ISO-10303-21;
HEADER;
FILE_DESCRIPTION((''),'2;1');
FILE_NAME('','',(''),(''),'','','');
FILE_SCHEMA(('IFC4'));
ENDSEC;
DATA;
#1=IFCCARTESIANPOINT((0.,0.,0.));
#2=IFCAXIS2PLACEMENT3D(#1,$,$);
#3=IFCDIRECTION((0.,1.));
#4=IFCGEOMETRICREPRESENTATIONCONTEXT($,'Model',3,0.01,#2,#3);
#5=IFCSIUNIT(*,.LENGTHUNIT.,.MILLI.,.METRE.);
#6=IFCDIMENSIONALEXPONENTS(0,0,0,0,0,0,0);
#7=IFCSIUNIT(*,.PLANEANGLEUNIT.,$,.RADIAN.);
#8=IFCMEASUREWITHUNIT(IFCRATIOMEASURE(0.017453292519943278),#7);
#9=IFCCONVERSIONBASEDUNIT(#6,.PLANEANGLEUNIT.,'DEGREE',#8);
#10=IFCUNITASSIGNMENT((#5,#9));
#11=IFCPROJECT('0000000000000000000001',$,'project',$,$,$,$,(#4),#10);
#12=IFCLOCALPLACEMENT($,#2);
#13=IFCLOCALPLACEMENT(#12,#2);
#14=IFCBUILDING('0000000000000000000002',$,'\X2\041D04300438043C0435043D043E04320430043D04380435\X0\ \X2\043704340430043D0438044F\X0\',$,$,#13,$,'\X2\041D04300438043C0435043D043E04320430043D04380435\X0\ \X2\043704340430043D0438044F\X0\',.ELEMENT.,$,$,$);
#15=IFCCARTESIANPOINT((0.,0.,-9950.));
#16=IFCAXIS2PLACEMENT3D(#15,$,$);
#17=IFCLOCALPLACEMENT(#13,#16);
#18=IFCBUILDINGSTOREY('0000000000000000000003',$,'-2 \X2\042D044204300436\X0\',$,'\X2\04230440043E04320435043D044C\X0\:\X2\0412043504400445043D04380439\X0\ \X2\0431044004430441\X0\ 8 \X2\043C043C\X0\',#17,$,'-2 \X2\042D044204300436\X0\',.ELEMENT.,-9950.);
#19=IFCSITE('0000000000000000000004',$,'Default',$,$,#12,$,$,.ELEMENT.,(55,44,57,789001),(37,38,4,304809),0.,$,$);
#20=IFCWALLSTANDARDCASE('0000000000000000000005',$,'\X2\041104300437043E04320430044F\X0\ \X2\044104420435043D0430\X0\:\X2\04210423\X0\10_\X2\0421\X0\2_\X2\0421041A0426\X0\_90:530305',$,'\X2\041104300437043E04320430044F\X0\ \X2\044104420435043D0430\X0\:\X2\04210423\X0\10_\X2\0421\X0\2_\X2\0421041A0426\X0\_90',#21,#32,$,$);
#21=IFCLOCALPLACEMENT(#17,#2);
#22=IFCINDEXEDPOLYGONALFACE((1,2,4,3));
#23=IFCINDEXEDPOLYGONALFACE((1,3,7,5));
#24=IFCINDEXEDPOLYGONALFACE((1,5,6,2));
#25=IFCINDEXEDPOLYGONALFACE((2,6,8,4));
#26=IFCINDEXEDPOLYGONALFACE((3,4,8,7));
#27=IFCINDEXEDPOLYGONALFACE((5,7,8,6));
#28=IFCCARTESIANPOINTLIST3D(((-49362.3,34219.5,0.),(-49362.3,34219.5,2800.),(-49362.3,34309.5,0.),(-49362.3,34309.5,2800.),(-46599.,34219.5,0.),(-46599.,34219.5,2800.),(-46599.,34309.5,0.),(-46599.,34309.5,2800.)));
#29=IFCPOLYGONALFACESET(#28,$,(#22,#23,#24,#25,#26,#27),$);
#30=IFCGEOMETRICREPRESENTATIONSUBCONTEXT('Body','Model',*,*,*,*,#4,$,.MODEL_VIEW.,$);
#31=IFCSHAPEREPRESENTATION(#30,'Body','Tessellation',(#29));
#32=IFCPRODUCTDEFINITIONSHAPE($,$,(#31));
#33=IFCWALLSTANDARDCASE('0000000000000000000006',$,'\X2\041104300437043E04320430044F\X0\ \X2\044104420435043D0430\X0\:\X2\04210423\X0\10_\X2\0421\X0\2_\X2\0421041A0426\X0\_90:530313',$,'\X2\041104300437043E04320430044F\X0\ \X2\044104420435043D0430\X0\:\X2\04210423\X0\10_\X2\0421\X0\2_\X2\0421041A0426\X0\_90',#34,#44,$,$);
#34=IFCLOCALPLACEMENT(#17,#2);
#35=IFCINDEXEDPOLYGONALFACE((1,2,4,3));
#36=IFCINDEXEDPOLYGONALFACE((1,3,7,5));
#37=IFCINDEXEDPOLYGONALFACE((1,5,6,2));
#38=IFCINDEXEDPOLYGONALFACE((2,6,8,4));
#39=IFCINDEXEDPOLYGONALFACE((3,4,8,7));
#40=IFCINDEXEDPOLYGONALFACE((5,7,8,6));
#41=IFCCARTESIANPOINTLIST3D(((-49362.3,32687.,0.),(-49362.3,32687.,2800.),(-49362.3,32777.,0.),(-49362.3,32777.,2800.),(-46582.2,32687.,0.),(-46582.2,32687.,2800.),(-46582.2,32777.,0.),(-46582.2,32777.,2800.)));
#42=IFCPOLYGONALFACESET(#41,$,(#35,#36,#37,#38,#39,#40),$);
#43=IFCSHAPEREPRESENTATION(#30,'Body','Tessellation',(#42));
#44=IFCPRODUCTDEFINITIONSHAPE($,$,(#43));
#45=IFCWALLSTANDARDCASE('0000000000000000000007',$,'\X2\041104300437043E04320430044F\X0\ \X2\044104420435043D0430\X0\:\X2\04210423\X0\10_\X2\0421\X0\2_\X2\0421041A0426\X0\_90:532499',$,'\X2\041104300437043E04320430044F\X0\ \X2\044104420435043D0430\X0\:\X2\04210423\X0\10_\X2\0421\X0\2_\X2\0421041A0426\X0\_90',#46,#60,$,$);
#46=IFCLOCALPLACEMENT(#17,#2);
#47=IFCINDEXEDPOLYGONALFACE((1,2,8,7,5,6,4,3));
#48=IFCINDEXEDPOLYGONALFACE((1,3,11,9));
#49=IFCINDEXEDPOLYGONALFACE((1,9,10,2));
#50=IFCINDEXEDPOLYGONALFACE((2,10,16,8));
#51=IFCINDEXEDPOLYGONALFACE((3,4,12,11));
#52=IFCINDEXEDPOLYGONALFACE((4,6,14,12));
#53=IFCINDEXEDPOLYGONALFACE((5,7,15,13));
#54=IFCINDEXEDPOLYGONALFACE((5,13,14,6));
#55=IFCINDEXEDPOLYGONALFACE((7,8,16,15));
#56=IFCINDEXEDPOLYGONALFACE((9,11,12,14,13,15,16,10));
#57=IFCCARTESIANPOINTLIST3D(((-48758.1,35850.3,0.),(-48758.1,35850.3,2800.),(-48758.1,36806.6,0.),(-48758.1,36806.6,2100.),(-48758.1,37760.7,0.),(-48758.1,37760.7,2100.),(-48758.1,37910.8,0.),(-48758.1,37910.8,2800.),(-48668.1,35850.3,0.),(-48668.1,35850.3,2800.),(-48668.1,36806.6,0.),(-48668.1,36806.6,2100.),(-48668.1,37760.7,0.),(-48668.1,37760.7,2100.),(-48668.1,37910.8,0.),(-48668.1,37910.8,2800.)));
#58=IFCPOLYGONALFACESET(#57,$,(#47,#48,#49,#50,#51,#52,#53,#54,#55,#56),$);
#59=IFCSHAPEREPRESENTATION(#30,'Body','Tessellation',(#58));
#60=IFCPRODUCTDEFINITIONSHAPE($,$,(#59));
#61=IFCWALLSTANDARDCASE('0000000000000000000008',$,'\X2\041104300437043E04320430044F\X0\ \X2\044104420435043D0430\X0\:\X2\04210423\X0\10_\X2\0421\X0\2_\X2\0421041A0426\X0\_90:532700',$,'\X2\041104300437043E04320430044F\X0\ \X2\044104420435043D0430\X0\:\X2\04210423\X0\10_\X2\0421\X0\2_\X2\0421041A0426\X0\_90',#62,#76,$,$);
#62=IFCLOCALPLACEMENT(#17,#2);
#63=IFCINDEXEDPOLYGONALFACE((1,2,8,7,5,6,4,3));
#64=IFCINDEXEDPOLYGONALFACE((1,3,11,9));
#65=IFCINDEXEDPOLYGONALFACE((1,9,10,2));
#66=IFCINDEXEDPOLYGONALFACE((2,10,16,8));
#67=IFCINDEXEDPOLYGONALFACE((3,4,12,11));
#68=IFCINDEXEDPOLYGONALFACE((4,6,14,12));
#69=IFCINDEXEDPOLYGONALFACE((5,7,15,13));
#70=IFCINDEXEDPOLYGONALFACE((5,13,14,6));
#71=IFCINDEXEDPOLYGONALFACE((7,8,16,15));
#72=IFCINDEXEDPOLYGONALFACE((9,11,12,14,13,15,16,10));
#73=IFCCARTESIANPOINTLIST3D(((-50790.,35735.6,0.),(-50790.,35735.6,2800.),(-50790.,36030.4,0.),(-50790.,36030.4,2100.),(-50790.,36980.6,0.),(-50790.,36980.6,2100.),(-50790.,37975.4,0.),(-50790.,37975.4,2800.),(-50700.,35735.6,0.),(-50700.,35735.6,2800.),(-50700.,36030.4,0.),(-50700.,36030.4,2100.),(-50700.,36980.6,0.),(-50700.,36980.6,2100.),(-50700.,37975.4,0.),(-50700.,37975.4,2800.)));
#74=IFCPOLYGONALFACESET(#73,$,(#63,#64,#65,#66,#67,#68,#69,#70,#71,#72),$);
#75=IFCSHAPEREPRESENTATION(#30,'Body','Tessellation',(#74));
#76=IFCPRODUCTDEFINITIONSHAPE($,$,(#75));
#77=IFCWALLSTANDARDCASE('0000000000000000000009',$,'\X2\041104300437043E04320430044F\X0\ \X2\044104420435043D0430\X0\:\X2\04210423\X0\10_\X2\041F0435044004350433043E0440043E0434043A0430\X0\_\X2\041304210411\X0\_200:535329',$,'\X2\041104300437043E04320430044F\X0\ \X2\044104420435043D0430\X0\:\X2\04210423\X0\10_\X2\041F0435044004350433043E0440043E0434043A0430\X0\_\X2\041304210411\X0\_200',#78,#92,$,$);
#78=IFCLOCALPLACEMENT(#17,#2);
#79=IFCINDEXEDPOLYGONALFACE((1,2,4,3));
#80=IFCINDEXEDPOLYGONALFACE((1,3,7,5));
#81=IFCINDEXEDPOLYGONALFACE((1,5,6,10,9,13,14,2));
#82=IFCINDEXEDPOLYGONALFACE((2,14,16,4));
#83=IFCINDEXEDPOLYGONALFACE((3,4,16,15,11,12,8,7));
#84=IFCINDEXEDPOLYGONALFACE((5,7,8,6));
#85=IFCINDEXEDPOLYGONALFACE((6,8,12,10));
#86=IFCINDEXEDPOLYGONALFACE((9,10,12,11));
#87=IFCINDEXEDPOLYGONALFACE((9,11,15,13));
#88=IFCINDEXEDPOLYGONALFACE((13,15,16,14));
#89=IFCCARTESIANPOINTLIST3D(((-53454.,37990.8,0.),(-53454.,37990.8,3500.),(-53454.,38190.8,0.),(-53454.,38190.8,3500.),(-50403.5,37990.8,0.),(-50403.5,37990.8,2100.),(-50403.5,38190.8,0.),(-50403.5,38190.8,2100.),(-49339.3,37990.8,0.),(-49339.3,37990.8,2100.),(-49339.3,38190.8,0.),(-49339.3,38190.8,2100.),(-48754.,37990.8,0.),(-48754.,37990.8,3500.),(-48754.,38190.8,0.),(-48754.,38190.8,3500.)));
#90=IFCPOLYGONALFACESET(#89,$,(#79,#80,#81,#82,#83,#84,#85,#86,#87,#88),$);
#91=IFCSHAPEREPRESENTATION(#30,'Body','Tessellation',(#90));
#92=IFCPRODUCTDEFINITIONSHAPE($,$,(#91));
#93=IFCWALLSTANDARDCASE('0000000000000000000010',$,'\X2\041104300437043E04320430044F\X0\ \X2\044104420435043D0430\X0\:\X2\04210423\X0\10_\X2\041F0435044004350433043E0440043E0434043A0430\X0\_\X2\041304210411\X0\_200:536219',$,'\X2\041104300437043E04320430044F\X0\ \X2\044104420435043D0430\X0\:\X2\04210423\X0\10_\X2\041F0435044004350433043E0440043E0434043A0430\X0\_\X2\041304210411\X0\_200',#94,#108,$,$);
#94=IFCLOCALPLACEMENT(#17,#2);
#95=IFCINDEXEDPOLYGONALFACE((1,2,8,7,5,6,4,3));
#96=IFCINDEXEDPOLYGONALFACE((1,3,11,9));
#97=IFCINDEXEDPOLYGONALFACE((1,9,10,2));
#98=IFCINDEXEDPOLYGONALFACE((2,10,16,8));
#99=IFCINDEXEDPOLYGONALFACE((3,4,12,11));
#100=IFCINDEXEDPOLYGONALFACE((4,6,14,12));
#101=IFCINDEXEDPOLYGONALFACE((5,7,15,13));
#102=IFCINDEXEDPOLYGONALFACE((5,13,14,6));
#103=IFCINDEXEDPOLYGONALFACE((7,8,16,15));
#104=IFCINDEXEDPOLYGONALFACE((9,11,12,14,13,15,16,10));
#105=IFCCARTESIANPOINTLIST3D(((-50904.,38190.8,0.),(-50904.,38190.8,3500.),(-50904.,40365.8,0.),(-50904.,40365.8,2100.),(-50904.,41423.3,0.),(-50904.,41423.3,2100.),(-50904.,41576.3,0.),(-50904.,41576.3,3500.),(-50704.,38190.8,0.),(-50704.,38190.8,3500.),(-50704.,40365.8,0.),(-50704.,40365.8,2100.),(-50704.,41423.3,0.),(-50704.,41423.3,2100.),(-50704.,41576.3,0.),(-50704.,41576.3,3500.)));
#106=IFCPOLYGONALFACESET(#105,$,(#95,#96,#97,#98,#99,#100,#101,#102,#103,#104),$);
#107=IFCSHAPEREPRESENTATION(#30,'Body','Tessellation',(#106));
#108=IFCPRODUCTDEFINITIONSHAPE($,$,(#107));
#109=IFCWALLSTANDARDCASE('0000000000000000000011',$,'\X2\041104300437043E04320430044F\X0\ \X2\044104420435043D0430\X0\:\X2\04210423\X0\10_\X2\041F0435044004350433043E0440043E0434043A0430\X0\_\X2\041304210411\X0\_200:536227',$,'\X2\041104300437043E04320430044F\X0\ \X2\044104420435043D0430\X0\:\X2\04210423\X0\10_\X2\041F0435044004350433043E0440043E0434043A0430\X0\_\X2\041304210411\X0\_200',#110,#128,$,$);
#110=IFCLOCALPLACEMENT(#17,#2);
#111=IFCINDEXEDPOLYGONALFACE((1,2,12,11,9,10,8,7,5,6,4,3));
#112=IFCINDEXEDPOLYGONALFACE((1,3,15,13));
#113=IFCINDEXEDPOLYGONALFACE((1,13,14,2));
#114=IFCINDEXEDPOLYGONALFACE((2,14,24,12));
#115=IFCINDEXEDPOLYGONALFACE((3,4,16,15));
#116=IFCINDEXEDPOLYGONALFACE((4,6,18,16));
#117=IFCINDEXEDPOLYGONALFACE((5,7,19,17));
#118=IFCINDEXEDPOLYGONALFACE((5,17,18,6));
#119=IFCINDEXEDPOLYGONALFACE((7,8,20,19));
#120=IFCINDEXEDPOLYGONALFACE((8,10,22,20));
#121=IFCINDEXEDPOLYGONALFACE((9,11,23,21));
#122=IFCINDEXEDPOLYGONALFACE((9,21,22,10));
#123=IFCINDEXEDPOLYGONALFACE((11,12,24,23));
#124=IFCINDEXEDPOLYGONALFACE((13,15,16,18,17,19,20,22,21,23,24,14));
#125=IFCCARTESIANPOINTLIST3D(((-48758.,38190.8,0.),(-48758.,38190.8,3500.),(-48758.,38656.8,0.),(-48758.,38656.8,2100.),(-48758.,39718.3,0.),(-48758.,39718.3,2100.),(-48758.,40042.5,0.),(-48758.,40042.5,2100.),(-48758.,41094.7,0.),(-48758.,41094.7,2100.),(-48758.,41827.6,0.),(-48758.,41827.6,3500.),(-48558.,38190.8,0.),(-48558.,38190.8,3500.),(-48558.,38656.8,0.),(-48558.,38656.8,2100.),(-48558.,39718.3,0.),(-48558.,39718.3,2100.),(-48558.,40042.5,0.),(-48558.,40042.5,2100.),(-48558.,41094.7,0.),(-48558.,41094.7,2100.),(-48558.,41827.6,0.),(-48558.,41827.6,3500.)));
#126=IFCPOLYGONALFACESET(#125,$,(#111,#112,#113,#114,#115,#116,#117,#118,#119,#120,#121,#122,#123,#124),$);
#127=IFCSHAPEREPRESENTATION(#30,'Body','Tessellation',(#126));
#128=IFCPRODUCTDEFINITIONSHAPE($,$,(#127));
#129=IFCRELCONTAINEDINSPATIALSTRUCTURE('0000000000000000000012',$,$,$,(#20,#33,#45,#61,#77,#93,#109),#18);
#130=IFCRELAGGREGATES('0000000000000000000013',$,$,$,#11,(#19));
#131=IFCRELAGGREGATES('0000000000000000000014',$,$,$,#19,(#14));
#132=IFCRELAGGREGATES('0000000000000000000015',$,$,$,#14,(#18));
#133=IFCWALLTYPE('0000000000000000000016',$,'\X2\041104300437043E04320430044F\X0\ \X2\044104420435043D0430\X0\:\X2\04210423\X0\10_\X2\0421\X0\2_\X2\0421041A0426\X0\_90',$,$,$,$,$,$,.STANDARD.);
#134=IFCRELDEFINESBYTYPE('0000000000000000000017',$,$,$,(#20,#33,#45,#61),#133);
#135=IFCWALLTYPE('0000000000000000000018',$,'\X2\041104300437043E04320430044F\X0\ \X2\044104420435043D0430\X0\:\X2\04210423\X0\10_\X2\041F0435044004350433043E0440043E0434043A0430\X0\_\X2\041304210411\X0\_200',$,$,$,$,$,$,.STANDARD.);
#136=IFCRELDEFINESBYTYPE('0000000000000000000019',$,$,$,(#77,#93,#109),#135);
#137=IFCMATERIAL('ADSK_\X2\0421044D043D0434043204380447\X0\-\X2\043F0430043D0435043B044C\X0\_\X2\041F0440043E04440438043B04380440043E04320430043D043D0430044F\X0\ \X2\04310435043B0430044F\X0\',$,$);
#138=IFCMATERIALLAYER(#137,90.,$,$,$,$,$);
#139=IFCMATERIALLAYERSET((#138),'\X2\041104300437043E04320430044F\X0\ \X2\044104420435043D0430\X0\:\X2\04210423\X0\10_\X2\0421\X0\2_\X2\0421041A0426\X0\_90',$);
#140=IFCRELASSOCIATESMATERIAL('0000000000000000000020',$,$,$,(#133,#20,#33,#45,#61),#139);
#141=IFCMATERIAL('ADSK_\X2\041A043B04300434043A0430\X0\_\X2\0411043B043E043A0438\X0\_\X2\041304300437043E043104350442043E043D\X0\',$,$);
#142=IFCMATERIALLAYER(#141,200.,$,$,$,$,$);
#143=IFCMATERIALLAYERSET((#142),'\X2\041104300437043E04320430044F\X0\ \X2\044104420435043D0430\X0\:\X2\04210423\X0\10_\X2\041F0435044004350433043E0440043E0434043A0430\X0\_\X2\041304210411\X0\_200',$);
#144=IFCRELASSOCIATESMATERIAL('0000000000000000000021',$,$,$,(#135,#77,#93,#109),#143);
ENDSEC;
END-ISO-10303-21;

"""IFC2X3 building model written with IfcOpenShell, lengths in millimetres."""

from ifc_helpers import new_model, entity, si_unit, converted_unit, direction, frame, frame_2d, origin, place, context, subcontext, project, spatial, rectangle, extrude, material, layer, layer_set, layer_usage, type_object, element, save


model = new_model("IFC2X3")

# Units and contexts
model_context = context("Model", 3, precision=0.01, world=origin(), true_north=direction((0.0, 1.0)))
body_context = subcontext(model_context, "Body", "Model", "MODEL_VIEW")
ifc_project = project(units=[si_unit("LENGTHUNIT", "METRE", prefix="MILLI"), converted_unit("PLANEANGLEUNIT", "DEGREE", entity("IfcRatioMeasure", 0.017453292519943278), si_unit("PLANEANGLEUNIT", "RADIAN"), dimensions=[0, 0, 0, 0, 0, 0, 0])], contexts=[model_context])

# Site, building, storey
site_placement = place(None, origin())
site = spatial("IfcSite", under=ifc_project, at=site_placement, Name="Default", CompositionType="ELEMENT", RefLatitude=(55, 44, 57, 789001), RefLongitude=(37, 38, 4, 304809), RefElevation=0.0)
building_placement = place(site_placement, origin())
building = spatial("IfcBuilding", under=site, at=building_placement, Name="Наименование здания", LongName="Наименование здания", CompositionType="ELEMENT")
storey_placement = place(building_placement, frame((0.0, 0.0, -9950.0)))
storey = spatial("IfcBuildingStorey", under=building, at=storey_placement, Name="-2 Этаж", ObjectType="Уровень:Верхний брус 8 мм", LongName="-2 Этаж", CompositionType="ELEMENT", Elevation=-9950.0)

# Shared definitions
ifc_material_1 = material(Name="ADSK_Сэндвич-панель_Профилированная белая")
ifc_layer_1 = layer(ifc_material_1, 90.0)
ifc_layer_set_1 = layer_set([ifc_layer_1], Name="Базовая стена:СУ10_С2_СКЦ_90")
ifc_layer_usage_1 = layer_usage(ifc_layer_set_1, "AXIS2", "NEGATIVE", 45.0)
wall_type_1 = type_object("IfcWallType", Name="Базовая стена:СУ10_С2_СКЦ_90", PredefinedType="STANDARD", material=ifc_layer_set_1)

# Walls
wall_1_placement = place(storey_placement, frame((-46599.0, 34264.5, 0.0), z_axis=(0.0, 0.0, 1.0), x_axis=(-1.0, 0.0, 0.0)))
element("IfcWallStandardCase", 1, at=wall_1_placement, inside=storey, type_object=wall_type_1, material=ifc_layer_usage_1, Name="Базовая стена:СУ10_С2_СКЦ_90:530305", ObjectType="Базовая стена:СУ10_С2_СКЦ_90", context=body_context, shape_type="SweptSolid", body=[
    extrude(rectangle(XDim=2763.4, YDim=90.0, at=frame_2d((1381.7, 0.0), x_axis=(-1.0, 0.0))), origin(), (0.0, 0.0, 1.0), 2800.0),
])
wall_2_placement = place(storey_placement, frame((-46582.2, 32732.0, 0.0), z_axis=(0.0, 0.0, 1.0), x_axis=(-1.0, 0.0, 0.0)))
element("IfcWallStandardCase", 2, at=wall_2_placement, inside=storey, type_object=wall_type_1, material=ifc_layer_usage_1, Name="Базовая стена:СУ10_С2_СКЦ_90:530313", ObjectType="Базовая стена:СУ10_С2_СКЦ_90", context=body_context, shape_type="SweptSolid", body=[
    extrude(rectangle(XDim=2780.1, YDim=90.0, at=frame_2d((1390.1, 0.0), x_axis=(-1.0, 0.0))), origin(), (0.0, 0.0, 1.0), 2800.0),
])

# Walls, openings
wall_3_placement = place(storey_placement, frame((-48713.1, 37910.8, 0.0), z_axis=(0.0, 0.0, 1.0), x_axis=(0.0, -1.0, 0.0)))
wall_3 = element("IfcWallStandardCase", 3, at=wall_3_placement, inside=storey, type_object=wall_type_1, material=ifc_layer_usage_1, Name="Базовая стена:СУ10_С2_СКЦ_90:532499", ObjectType="Базовая стена:СУ10_С2_СКЦ_90", context=body_context, shape_type="SweptSolid", body=[
    extrude(rectangle(XDim=2060.4, YDim=90.0, at=frame_2d((1030.2, 0.0), x_axis=(1.0, 0.0))), origin(), (0.0, 0.0, 1.0), 2800.0),
])
opening_1_placement = place(wall_3_placement, origin())
element("IfcOpeningElement", 4, at=opening_1_placement, cuts=wall_3, ObjectType="Opening", context=body_context, shape_type="SweptSolid", body=[
    extrude(rectangle(XDim=2100.0, YDim=954.2, at=frame_2d((0.0, 0.0), x_axis=(1.0, 0.0))), frame((627.1, -45.0, 1050.0), z_axis=(0.0, 1.0, 0.0), x_axis=(0.0, 0.0, -1.0)), (0.0, 0.0, 1.0), 90.0),
])
wall_4_placement = place(storey_placement, frame((-50745.0, 37975.4, 0.0), z_axis=(0.0, 0.0, 1.0), x_axis=(0.0, -1.0, 0.0)))
wall_4 = element("IfcWallStandardCase", 5, at=wall_4_placement, inside=storey, type_object=wall_type_1, material=ifc_layer_usage_1, Name="Базовая стена:СУ10_С2_СКЦ_90:532700", ObjectType="Базовая стена:СУ10_С2_СКЦ_90", context=body_context, shape_type="SweptSolid", body=[
    extrude(rectangle(XDim=2239.8, YDim=90.0, at=frame_2d((1119.9, 0.0), x_axis=(1.0, 0.0))), origin(), (0.0, 0.0, 1.0), 2800.0),
])
opening_2_placement = place(wall_4_placement, origin())
element("IfcOpeningElement", 6, at=opening_2_placement, cuts=wall_4, ObjectType="Opening", context=body_context, shape_type="SweptSolid", body=[
    extrude(rectangle(XDim=2100.0, YDim=950.2, at=frame_2d((0.0, 0.0), x_axis=(1.0, 0.0))), frame((1469.9, -45.0, 1050.0), z_axis=(0.0, 1.0, 0.0), x_axis=(0.0, 0.0, -1.0)), (0.0, 0.0, 1.0), 90.0),
])
ifc_material_2 = material(Name="ADSK_Кладка_Блоки_Газобетон")
ifc_layer_2 = layer(ifc_material_2, 200.0)
ifc_layer_set_2 = layer_set([ifc_layer_2], Name="Базовая стена:СУ10_Перегородка_ГСБ_200")
ifc_layer_usage_2 = layer_usage(ifc_layer_set_2, "AXIS2", "NEGATIVE", 100.0)
wall_type_2 = type_object("IfcWallType", Name="Базовая стена:СУ10_Перегородка_ГСБ_200", PredefinedType="STANDARD", material=ifc_layer_set_2)
wall_5_placement = place(storey_placement, frame((-48754.0, 38090.8, 0.0), z_axis=(0.0, 0.0, 1.0), x_axis=(-1.0, 0.0, 0.0)))
wall_5 = element("IfcWallStandardCase", 7, at=wall_5_placement, inside=storey, type_object=wall_type_2, material=ifc_layer_usage_2, Name="Базовая стена:СУ10_Перегородка_ГСБ_200:535329", ObjectType="Базовая стена:СУ10_Перегородка_ГСБ_200", context=body_context, shape_type="SweptSolid", body=[
    extrude(rectangle(XDim=4700.0, YDim=200.0, at=frame_2d((2350.0, 0.0), x_axis=(1.0, 0.0))), origin(), (0.0, 0.0, 1.0), 3500.0),
])
opening_3_placement = place(wall_5_placement, origin())
element("IfcOpeningElement", 8, at=opening_3_placement, cuts=wall_5, ObjectType="Opening", context=body_context, shape_type="SweptSolid", body=[
    extrude(rectangle(XDim=2100.0, YDim=1064.2, at=frame_2d((0.0, 0.0), x_axis=(1.0, 0.0))), frame((1117.4, -100.0, 1050.0), z_axis=(0.0, 1.0, 0.0), x_axis=(0.0, 0.0, -1.0)), (0.0, 0.0, 1.0), 200.0),
])
wall_6_placement = place(storey_placement, frame((-50804.0, 38190.8, 0.0), z_axis=(0.0, 0.0, 1.0), x_axis=(0.0, 1.0, 0.0)))
wall_6 = element("IfcWallStandardCase", 9, at=wall_6_placement, inside=storey, type_object=wall_type_2, material=ifc_layer_usage_2, Name="Базовая стена:СУ10_Перегородка_ГСБ_200:536219", ObjectType="Базовая стена:СУ10_Перегородка_ГСБ_200", context=body_context, shape_type="SweptSolid", body=[
    extrude(rectangle(XDim=3385.5, YDim=200.0, at=frame_2d((1692.8, 0.0), x_axis=(-1.0, 0.0))), origin(), (0.0, 0.0, 1.0), 3500.0),
])
opening_4_placement = place(wall_6_placement, origin())
element("IfcOpeningElement", 10, at=opening_4_placement, cuts=wall_6, ObjectType="Opening", context=body_context, shape_type="SweptSolid", body=[
    extrude(rectangle(XDim=2100.0, YDim=1057.5, at=frame_2d((0.0, 0.0), x_axis=(1.0, 0.0))), frame((2703.8, -100.0, 1050.0), z_axis=(0.0, 1.0, 0.0), x_axis=(0.0, 0.0, -1.0)), (0.0, 0.0, 1.0), 200.0),
])

# Wall, openings
wall_7_placement = place(storey_placement, frame((-48658.0, 38190.8, 0.0), z_axis=(0.0, 0.0, 1.0), x_axis=(0.0, 1.0, 0.0)))
wall_7 = element("IfcWallStandardCase", 11, at=wall_7_placement, inside=storey, type_object=wall_type_2, material=ifc_layer_usage_2, Name="Базовая стена:СУ10_Перегородка_ГСБ_200:536227", ObjectType="Базовая стена:СУ10_Перегородка_ГСБ_200", context=body_context, shape_type="SweptSolid", body=[
    extrude(rectangle(XDim=3636.9, YDim=200.0, at=frame_2d((1818.4, 0.0), x_axis=(-1.0, 0.0))), origin(), (0.0, 0.0, 1.0), 3500.0),
])
opening_5_placement = place(wall_7_placement, origin())
element("IfcOpeningElement", 12, at=opening_5_placement, cuts=wall_7, ObjectType="Opening", context=body_context, shape_type="SweptSolid", body=[
    extrude(rectangle(XDim=2100.0, YDim=1052.2, at=frame_2d((0.0, 0.0), x_axis=(1.0, 0.0))), frame((2377.8, -100.0, 1050.0), z_axis=(0.0, 1.0, 0.0), x_axis=(0.0, 0.0, -1.0)), (0.0, 0.0, 1.0), 200.0),
])
opening_6_placement = place(wall_7_placement, origin())
element("IfcOpeningElement", 13, at=opening_6_placement, cuts=wall_7, ObjectType="Opening", context=body_context, shape_type="SweptSolid", body=[
    extrude(rectangle(XDim=2100.0, YDim=1061.5, at=frame_2d((0.0, 0.0), x_axis=(1.0, 0.0))), frame((996.8, -100.0, 1050.0), z_axis=(0.0, 1.0, 0.0), x_axis=(0.0, 0.0, -1.0)), (0.0, 0.0, 1.0), 200.0),
])

save(model, "model.ifc")
